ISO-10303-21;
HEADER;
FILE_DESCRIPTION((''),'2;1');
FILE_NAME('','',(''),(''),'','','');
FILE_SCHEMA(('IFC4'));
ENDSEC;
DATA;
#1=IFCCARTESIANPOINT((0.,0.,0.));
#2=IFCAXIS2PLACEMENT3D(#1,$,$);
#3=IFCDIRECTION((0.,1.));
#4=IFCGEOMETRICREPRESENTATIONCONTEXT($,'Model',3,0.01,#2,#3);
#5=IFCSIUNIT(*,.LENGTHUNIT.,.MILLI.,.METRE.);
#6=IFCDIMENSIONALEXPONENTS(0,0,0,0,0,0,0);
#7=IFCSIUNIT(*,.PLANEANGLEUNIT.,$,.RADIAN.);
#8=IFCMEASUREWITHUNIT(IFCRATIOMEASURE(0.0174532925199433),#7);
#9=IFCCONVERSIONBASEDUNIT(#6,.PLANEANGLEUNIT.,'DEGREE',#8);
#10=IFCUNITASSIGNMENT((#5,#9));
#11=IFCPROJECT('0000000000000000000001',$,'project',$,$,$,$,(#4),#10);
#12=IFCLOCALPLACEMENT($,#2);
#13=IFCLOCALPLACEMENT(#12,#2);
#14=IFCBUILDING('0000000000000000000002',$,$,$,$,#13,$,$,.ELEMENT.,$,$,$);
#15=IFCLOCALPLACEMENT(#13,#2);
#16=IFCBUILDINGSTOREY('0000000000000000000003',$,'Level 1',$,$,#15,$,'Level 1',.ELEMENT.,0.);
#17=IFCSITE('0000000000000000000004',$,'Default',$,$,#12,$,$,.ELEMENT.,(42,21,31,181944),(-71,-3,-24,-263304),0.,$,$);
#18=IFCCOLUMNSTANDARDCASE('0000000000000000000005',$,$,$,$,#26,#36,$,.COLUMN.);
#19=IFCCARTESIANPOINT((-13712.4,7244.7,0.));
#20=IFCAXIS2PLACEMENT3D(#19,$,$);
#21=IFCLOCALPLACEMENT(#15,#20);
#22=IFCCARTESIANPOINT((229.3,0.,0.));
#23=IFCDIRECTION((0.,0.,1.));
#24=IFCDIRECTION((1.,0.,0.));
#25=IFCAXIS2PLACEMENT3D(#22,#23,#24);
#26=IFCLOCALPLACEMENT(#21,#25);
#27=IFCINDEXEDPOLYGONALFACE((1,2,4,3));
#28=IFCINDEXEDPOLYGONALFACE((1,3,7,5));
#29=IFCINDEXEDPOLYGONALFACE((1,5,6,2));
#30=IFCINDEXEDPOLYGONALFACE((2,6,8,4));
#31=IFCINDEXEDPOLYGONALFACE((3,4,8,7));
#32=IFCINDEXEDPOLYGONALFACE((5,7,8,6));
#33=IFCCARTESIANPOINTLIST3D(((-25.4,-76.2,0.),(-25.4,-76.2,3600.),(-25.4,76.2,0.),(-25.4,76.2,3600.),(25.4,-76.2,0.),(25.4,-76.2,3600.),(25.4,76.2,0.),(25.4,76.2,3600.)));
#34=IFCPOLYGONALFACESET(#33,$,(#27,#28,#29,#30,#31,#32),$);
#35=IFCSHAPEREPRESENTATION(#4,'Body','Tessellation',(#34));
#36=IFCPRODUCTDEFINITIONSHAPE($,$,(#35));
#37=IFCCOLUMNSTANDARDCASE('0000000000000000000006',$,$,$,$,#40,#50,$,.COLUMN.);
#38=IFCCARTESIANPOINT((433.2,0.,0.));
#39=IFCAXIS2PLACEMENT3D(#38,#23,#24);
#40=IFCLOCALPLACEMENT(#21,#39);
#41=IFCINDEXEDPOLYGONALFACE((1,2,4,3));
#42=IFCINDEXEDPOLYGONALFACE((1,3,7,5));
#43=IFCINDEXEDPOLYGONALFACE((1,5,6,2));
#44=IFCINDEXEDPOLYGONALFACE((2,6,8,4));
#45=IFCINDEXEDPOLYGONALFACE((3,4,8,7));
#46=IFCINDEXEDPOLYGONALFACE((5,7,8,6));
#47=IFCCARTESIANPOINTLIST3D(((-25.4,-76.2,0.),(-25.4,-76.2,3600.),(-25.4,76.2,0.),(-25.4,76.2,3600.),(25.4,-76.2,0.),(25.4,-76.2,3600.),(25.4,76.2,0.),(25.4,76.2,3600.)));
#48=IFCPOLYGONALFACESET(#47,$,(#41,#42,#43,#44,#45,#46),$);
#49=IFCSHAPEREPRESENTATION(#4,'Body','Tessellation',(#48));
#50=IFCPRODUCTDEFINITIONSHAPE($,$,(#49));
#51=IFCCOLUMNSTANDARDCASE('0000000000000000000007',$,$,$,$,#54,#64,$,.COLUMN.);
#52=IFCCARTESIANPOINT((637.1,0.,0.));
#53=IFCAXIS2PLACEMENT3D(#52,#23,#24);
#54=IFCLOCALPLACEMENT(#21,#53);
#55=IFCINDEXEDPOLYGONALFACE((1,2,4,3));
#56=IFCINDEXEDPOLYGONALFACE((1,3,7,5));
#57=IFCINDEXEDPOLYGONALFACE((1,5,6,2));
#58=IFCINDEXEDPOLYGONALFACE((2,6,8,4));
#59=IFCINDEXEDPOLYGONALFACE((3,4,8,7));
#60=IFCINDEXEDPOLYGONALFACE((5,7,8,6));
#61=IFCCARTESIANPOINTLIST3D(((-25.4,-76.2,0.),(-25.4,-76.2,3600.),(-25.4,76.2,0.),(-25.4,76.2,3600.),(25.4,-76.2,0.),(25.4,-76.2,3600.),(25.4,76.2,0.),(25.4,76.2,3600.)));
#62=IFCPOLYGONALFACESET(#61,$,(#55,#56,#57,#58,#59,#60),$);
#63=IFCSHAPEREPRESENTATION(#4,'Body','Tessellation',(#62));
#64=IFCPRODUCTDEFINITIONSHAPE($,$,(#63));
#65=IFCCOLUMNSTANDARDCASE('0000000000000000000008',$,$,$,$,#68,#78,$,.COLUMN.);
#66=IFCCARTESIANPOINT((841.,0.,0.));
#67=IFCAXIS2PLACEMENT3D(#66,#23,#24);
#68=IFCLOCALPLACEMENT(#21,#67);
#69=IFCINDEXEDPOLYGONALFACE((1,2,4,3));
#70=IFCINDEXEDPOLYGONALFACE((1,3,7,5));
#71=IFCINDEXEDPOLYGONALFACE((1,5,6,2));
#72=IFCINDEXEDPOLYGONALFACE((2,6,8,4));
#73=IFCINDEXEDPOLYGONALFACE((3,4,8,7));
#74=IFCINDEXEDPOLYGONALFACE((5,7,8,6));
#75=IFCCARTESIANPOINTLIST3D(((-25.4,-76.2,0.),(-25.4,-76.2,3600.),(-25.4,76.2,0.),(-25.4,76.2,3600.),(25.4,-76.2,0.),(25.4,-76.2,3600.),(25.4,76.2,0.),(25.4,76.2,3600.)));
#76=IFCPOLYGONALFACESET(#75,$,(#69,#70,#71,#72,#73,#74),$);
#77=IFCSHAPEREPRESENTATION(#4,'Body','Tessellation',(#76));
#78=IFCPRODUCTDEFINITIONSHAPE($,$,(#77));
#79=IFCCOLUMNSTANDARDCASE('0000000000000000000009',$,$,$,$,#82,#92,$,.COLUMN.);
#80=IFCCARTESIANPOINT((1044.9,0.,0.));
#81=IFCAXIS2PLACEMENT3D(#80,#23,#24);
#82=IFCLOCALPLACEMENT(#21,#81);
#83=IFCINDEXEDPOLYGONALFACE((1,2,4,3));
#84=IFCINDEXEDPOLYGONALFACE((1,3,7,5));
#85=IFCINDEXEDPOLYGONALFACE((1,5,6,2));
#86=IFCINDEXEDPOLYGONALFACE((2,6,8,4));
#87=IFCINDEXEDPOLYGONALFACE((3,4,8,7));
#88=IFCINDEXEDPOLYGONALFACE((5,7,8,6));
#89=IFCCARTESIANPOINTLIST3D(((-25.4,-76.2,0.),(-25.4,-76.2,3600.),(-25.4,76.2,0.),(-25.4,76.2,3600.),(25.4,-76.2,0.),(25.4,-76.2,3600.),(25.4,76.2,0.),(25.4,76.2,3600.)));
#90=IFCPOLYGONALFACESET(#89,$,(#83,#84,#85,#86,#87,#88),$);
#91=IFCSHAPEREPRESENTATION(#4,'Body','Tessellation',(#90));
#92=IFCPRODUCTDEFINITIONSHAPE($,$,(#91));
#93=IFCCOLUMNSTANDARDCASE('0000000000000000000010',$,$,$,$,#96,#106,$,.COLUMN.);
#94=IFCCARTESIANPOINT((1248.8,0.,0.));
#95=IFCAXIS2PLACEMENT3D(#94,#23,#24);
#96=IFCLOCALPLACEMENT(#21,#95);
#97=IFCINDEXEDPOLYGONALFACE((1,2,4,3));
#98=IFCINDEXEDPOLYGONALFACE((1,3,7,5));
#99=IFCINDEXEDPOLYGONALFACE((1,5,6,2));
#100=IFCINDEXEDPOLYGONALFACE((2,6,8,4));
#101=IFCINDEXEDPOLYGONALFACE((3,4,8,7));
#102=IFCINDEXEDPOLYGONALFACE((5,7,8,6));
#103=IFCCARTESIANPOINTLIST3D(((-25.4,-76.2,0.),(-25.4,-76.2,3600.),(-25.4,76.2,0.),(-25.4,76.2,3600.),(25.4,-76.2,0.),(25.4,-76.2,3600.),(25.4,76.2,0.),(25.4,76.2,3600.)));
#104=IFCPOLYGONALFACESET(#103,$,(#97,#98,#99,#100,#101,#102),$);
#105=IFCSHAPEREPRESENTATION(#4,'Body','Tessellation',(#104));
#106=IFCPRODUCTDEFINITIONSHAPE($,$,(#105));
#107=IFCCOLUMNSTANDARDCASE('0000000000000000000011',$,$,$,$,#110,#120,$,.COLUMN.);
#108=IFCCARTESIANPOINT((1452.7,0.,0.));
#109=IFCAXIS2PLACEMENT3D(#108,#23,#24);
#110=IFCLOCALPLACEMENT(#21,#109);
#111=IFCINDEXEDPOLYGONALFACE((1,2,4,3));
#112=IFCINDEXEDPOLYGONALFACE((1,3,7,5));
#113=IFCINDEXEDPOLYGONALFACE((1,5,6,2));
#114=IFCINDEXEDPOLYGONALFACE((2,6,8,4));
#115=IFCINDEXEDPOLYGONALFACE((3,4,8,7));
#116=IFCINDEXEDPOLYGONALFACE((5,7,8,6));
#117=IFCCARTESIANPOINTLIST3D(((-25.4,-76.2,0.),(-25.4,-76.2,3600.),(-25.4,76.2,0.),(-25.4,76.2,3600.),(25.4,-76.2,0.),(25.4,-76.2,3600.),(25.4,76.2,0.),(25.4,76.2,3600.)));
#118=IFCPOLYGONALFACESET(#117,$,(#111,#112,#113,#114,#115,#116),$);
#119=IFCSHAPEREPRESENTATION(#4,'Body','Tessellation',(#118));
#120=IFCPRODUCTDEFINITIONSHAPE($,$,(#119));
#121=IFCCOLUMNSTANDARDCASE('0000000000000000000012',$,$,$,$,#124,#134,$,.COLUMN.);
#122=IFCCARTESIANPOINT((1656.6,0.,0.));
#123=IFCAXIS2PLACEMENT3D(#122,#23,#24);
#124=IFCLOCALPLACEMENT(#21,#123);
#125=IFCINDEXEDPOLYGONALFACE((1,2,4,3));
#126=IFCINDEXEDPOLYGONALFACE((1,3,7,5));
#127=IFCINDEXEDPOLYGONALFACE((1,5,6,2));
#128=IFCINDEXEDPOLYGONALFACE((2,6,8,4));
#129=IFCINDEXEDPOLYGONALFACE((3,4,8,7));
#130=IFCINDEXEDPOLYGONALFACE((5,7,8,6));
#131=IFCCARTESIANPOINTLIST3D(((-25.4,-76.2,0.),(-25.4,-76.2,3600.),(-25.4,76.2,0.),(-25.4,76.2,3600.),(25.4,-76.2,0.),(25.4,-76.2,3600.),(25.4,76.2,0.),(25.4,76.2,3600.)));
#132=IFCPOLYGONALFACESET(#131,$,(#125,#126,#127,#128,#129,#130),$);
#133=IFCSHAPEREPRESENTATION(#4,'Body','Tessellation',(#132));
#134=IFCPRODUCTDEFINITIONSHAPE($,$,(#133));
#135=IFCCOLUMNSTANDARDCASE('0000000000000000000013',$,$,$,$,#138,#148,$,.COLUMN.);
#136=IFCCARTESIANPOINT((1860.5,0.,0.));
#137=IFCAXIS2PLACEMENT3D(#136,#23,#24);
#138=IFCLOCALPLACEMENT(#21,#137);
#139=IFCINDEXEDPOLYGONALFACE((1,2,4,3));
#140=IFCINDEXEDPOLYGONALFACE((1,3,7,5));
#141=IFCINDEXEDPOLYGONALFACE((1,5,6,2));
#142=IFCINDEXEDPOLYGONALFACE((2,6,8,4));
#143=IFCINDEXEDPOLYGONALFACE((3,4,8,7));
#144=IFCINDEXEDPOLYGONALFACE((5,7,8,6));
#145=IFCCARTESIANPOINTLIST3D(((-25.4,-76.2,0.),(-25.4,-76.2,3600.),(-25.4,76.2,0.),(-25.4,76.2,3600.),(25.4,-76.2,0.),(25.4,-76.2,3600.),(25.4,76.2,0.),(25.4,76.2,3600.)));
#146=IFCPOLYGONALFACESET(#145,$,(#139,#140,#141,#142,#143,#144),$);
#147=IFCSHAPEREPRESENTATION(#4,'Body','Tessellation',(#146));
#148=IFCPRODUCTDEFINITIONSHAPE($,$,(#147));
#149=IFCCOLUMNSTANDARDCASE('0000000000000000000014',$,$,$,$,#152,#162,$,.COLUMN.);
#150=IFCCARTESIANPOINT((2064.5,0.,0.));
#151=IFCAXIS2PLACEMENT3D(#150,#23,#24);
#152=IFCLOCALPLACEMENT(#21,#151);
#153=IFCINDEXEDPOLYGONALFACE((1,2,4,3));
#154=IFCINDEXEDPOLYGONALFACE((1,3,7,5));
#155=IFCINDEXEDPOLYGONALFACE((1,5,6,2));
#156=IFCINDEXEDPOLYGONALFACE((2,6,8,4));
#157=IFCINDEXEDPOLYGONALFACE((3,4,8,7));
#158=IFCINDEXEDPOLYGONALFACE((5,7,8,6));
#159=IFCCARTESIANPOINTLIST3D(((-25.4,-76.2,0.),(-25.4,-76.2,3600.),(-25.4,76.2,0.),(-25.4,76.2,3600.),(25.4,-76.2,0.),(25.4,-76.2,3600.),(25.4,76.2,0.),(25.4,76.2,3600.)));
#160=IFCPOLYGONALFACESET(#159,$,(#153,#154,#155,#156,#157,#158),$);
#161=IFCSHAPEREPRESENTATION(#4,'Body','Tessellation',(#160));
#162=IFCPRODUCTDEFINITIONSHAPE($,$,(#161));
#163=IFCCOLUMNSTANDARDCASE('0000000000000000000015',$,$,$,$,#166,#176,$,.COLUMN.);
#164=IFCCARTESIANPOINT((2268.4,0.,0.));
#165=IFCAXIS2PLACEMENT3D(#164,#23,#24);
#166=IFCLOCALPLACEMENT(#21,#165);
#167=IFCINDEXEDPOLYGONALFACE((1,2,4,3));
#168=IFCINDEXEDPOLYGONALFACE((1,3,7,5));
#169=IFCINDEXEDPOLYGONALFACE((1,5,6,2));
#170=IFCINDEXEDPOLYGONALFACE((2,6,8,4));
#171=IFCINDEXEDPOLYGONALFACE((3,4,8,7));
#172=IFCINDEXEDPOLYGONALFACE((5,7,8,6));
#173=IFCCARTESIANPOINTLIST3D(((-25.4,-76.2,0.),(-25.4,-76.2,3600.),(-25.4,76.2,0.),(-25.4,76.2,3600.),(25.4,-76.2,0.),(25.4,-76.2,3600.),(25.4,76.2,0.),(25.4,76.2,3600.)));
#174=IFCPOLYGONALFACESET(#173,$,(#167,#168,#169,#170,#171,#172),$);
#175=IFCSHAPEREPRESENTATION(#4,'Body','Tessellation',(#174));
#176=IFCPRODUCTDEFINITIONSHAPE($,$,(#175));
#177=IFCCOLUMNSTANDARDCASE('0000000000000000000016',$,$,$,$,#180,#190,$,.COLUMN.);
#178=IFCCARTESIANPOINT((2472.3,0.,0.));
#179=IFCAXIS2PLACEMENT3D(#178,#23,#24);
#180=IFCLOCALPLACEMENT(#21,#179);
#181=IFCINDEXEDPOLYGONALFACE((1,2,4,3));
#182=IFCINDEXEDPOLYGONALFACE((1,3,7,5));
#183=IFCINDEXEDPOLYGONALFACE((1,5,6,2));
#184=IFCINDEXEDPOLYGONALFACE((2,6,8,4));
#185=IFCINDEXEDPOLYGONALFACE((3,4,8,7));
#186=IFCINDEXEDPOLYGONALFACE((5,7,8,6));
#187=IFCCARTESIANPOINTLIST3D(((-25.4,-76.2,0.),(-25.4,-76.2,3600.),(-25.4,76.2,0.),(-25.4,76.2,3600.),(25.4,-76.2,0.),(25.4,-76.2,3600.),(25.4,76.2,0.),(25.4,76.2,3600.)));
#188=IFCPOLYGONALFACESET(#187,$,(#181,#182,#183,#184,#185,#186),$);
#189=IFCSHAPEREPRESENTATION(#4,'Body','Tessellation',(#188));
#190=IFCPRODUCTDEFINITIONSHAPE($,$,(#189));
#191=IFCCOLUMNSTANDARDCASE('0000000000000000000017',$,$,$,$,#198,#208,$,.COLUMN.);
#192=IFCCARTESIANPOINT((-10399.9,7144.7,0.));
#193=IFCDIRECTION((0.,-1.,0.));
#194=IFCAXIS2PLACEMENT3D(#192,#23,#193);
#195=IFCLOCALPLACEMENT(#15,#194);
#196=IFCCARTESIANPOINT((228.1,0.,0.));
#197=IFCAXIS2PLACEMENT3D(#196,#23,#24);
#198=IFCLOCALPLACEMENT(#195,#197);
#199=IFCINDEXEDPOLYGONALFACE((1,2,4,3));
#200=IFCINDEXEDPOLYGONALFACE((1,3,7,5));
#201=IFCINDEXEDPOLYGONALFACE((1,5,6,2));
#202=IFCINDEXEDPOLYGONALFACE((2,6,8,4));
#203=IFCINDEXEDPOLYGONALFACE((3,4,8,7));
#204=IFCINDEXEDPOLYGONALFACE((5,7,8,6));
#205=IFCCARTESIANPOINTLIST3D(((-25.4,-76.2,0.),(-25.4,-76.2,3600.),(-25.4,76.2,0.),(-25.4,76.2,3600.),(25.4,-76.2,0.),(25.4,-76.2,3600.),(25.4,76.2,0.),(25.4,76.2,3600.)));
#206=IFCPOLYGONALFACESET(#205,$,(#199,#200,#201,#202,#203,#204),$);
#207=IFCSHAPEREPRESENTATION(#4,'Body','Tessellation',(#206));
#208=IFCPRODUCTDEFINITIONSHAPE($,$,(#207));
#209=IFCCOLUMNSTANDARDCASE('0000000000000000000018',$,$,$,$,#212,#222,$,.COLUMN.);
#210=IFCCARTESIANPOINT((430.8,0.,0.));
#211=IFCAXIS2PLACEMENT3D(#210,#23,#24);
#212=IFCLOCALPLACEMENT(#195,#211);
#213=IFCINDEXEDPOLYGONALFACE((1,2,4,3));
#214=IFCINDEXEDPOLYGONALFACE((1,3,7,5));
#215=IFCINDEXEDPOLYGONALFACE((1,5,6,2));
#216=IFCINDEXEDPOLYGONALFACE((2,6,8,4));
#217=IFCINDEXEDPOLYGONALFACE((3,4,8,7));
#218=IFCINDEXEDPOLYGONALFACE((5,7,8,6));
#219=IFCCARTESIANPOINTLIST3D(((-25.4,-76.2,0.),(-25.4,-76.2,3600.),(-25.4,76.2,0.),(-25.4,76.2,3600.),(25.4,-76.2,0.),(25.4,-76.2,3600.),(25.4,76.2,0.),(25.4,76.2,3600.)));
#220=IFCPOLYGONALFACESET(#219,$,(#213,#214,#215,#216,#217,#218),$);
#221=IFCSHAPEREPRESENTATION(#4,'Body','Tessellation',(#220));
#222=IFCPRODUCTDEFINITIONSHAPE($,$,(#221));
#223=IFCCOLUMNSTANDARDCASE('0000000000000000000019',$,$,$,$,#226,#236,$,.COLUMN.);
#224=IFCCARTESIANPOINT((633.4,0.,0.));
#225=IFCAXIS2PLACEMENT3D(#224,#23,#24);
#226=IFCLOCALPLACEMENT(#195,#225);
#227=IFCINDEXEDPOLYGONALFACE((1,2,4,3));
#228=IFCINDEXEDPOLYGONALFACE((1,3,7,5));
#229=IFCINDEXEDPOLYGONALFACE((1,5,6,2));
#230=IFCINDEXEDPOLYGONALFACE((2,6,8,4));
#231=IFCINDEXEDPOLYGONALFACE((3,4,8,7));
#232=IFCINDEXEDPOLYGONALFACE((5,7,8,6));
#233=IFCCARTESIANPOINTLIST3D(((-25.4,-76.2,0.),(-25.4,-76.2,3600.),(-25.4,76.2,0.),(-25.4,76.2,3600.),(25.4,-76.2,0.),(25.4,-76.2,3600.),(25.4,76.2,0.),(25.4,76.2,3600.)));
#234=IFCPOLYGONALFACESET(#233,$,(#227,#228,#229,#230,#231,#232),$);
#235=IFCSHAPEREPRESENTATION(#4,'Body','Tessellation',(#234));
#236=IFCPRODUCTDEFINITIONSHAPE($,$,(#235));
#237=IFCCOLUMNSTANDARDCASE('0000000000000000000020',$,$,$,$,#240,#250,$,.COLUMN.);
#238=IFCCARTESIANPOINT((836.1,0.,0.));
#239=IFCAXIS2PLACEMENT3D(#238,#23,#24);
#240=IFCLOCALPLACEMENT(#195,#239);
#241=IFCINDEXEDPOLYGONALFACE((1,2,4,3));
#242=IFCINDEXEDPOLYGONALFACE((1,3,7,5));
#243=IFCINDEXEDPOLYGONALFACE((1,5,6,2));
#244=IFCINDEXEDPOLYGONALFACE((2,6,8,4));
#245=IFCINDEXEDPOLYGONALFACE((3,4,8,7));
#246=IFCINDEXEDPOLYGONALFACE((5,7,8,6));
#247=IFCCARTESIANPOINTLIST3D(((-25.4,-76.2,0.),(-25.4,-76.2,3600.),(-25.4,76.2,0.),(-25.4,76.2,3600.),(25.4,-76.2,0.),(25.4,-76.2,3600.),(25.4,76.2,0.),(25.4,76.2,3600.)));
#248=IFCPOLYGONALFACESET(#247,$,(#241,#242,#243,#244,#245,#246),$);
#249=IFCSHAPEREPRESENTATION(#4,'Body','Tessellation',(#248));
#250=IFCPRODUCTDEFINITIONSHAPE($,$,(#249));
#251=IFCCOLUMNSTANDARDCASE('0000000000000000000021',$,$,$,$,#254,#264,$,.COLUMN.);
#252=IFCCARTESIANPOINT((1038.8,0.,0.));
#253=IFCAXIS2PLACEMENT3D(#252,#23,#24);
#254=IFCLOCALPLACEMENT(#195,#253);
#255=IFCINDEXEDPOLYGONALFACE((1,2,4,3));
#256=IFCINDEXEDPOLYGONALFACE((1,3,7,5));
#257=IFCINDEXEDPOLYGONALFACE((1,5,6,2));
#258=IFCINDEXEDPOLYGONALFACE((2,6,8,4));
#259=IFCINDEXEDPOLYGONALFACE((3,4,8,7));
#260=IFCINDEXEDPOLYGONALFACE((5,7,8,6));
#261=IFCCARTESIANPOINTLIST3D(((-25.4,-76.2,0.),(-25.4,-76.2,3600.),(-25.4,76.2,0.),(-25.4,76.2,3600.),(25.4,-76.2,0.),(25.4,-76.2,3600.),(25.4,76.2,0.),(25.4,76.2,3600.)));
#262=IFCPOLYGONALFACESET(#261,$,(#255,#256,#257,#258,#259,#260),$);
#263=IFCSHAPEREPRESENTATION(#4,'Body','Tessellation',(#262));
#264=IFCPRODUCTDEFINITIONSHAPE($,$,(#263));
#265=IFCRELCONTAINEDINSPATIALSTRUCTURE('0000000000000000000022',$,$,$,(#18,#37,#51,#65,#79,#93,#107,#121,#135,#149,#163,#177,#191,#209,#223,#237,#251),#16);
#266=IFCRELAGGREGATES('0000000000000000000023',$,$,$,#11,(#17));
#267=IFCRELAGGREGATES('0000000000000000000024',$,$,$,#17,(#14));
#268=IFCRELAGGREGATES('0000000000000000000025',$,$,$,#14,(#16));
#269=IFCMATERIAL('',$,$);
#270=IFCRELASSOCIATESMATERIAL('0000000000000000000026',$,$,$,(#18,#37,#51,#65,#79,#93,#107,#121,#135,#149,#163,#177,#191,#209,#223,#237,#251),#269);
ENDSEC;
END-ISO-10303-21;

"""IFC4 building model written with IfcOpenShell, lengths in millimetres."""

from ifc_helpers import new_model, entity, si_unit, converted_unit, direction, frame, origin, place, context, project, spatial, rectangle, extrude, material, element, save


model = new_model("IFC4")

# Units and contexts
model_context = context("Model", 3, precision=0.01, world=origin(), true_north=direction((0.0, 1.0)))
ifc_project = project(units=[si_unit("LENGTHUNIT", "METRE", prefix="MILLI"), converted_unit("PLANEANGLEUNIT", "DEGREE", entity("IfcRatioMeasure", 0.0174532925199433), si_unit("PLANEANGLEUNIT", "RADIAN"), dimensions=[0, 0, 0, 0, 0, 0, 0])], contexts=[model_context])

# Site, building, storey
site_placement = place(None, origin())
site = spatial("IfcSite", under=ifc_project, at=site_placement, Name="Default", CompositionType="ELEMENT", RefLatitude=(42, 21, 31, 181944), RefLongitude=(-71, -3, -24, -263304), RefElevation=0.0)
building_placement = place(site_placement, origin())
building = spatial("IfcBuilding", under=site, at=building_placement, CompositionType="ELEMENT")
storey_placement = place(building_placement, origin())
storey = spatial("IfcBuildingStorey", under=building, at=storey_placement, Name="Level 1", LongName="Level 1", CompositionType="ELEMENT", Elevation=0.0)

# Columns
ifc_material_1 = material(Name="")
placement_1 = place(storey_placement, frame((-13712.4, 7244.7, 0.0)))
for number, where, z_axis, x_axis in (
    (1, (229.3, 0.0, 0.0), (0.0, 0.0, 1.0), (1.0, 0.0, 0.0)),
    (2, (433.2, 0.0, 0.0), (0.0, 0.0, 1.0), (1.0, 0.0, 0.0)),
    (3, (637.1, 0.0, 0.0), (0.0, 0.0, 1.0), (1.0, 0.0, 0.0)),
    (4, (841.0, 0.0, 0.0), (0.0, 0.0, 1.0), (1.0, 0.0, 0.0)),
    (5, (1044.9, 0.0, 0.0), (0.0, 0.0, 1.0), (1.0, 0.0, 0.0)),
    (6, (1248.8, 0.0, 0.0), (0.0, 0.0, 1.0), (1.0, 0.0, 0.0)),
    (7, (1452.7, 0.0, 0.0), (0.0, 0.0, 1.0), (1.0, 0.0, 0.0)),
    (8, (1656.6, 0.0, 0.0), (0.0, 0.0, 1.0), (1.0, 0.0, 0.0)),
    (9, (1860.5, 0.0, 0.0), (0.0, 0.0, 1.0), (1.0, 0.0, 0.0)),
    (10, (2064.5, 0.0, 0.0), (0.0, 0.0, 1.0), (1.0, 0.0, 0.0)),
    (11, (2268.4, 0.0, 0.0), (0.0, 0.0, 1.0), (1.0, 0.0, 0.0)),
    (12, (2472.3, 0.0, 0.0), (0.0, 0.0, 1.0), (1.0, 0.0, 0.0)),
):
    element("IfcColumnStandardCase", number, at=place(placement_1, frame(where, z_axis=z_axis, x_axis=x_axis)), inside=storey, material=ifc_material_1, PredefinedType="COLUMN", context=model_context, shape_type="SweptSolid", body=[
        extrude(rectangle(XDim=50.8, YDim=152.4), origin(), (0.0, 0.0, 1.0), 3600.0),
    ])
placement_2 = place(storey_placement, frame((-10399.9, 7144.7, 0.0), z_axis=(0.0, 0.0, 1.0), x_axis=(0.0, -1.0, 0.0)))
for number, where, z_axis, x_axis in (
    (13, (228.1, 0.0, 0.0), (0.0, 0.0, 1.0), (1.0, 0.0, 0.0)),
    (14, (430.8, 0.0, 0.0), (0.0, 0.0, 1.0), (1.0, 0.0, 0.0)),
    (15, (633.4, 0.0, 0.0), (0.0, 0.0, 1.0), (1.0, 0.0, 0.0)),
    (16, (836.1, 0.0, 0.0), (0.0, 0.0, 1.0), (1.0, 0.0, 0.0)),
    (17, (1038.8, 0.0, 0.0), (0.0, 0.0, 1.0), (1.0, 0.0, 0.0)),
):
    element("IfcColumnStandardCase", number, at=place(placement_2, frame(where, z_axis=z_axis, x_axis=x_axis)), inside=storey, material=ifc_material_1, PredefinedType="COLUMN", context=model_context, shape_type="SweptSolid", body=[
        extrude(rectangle(XDim=50.8, YDim=152.4), origin(), (0.0, 0.0, 1.0), 3600.0),
    ])

save(model, "model.ifc")
